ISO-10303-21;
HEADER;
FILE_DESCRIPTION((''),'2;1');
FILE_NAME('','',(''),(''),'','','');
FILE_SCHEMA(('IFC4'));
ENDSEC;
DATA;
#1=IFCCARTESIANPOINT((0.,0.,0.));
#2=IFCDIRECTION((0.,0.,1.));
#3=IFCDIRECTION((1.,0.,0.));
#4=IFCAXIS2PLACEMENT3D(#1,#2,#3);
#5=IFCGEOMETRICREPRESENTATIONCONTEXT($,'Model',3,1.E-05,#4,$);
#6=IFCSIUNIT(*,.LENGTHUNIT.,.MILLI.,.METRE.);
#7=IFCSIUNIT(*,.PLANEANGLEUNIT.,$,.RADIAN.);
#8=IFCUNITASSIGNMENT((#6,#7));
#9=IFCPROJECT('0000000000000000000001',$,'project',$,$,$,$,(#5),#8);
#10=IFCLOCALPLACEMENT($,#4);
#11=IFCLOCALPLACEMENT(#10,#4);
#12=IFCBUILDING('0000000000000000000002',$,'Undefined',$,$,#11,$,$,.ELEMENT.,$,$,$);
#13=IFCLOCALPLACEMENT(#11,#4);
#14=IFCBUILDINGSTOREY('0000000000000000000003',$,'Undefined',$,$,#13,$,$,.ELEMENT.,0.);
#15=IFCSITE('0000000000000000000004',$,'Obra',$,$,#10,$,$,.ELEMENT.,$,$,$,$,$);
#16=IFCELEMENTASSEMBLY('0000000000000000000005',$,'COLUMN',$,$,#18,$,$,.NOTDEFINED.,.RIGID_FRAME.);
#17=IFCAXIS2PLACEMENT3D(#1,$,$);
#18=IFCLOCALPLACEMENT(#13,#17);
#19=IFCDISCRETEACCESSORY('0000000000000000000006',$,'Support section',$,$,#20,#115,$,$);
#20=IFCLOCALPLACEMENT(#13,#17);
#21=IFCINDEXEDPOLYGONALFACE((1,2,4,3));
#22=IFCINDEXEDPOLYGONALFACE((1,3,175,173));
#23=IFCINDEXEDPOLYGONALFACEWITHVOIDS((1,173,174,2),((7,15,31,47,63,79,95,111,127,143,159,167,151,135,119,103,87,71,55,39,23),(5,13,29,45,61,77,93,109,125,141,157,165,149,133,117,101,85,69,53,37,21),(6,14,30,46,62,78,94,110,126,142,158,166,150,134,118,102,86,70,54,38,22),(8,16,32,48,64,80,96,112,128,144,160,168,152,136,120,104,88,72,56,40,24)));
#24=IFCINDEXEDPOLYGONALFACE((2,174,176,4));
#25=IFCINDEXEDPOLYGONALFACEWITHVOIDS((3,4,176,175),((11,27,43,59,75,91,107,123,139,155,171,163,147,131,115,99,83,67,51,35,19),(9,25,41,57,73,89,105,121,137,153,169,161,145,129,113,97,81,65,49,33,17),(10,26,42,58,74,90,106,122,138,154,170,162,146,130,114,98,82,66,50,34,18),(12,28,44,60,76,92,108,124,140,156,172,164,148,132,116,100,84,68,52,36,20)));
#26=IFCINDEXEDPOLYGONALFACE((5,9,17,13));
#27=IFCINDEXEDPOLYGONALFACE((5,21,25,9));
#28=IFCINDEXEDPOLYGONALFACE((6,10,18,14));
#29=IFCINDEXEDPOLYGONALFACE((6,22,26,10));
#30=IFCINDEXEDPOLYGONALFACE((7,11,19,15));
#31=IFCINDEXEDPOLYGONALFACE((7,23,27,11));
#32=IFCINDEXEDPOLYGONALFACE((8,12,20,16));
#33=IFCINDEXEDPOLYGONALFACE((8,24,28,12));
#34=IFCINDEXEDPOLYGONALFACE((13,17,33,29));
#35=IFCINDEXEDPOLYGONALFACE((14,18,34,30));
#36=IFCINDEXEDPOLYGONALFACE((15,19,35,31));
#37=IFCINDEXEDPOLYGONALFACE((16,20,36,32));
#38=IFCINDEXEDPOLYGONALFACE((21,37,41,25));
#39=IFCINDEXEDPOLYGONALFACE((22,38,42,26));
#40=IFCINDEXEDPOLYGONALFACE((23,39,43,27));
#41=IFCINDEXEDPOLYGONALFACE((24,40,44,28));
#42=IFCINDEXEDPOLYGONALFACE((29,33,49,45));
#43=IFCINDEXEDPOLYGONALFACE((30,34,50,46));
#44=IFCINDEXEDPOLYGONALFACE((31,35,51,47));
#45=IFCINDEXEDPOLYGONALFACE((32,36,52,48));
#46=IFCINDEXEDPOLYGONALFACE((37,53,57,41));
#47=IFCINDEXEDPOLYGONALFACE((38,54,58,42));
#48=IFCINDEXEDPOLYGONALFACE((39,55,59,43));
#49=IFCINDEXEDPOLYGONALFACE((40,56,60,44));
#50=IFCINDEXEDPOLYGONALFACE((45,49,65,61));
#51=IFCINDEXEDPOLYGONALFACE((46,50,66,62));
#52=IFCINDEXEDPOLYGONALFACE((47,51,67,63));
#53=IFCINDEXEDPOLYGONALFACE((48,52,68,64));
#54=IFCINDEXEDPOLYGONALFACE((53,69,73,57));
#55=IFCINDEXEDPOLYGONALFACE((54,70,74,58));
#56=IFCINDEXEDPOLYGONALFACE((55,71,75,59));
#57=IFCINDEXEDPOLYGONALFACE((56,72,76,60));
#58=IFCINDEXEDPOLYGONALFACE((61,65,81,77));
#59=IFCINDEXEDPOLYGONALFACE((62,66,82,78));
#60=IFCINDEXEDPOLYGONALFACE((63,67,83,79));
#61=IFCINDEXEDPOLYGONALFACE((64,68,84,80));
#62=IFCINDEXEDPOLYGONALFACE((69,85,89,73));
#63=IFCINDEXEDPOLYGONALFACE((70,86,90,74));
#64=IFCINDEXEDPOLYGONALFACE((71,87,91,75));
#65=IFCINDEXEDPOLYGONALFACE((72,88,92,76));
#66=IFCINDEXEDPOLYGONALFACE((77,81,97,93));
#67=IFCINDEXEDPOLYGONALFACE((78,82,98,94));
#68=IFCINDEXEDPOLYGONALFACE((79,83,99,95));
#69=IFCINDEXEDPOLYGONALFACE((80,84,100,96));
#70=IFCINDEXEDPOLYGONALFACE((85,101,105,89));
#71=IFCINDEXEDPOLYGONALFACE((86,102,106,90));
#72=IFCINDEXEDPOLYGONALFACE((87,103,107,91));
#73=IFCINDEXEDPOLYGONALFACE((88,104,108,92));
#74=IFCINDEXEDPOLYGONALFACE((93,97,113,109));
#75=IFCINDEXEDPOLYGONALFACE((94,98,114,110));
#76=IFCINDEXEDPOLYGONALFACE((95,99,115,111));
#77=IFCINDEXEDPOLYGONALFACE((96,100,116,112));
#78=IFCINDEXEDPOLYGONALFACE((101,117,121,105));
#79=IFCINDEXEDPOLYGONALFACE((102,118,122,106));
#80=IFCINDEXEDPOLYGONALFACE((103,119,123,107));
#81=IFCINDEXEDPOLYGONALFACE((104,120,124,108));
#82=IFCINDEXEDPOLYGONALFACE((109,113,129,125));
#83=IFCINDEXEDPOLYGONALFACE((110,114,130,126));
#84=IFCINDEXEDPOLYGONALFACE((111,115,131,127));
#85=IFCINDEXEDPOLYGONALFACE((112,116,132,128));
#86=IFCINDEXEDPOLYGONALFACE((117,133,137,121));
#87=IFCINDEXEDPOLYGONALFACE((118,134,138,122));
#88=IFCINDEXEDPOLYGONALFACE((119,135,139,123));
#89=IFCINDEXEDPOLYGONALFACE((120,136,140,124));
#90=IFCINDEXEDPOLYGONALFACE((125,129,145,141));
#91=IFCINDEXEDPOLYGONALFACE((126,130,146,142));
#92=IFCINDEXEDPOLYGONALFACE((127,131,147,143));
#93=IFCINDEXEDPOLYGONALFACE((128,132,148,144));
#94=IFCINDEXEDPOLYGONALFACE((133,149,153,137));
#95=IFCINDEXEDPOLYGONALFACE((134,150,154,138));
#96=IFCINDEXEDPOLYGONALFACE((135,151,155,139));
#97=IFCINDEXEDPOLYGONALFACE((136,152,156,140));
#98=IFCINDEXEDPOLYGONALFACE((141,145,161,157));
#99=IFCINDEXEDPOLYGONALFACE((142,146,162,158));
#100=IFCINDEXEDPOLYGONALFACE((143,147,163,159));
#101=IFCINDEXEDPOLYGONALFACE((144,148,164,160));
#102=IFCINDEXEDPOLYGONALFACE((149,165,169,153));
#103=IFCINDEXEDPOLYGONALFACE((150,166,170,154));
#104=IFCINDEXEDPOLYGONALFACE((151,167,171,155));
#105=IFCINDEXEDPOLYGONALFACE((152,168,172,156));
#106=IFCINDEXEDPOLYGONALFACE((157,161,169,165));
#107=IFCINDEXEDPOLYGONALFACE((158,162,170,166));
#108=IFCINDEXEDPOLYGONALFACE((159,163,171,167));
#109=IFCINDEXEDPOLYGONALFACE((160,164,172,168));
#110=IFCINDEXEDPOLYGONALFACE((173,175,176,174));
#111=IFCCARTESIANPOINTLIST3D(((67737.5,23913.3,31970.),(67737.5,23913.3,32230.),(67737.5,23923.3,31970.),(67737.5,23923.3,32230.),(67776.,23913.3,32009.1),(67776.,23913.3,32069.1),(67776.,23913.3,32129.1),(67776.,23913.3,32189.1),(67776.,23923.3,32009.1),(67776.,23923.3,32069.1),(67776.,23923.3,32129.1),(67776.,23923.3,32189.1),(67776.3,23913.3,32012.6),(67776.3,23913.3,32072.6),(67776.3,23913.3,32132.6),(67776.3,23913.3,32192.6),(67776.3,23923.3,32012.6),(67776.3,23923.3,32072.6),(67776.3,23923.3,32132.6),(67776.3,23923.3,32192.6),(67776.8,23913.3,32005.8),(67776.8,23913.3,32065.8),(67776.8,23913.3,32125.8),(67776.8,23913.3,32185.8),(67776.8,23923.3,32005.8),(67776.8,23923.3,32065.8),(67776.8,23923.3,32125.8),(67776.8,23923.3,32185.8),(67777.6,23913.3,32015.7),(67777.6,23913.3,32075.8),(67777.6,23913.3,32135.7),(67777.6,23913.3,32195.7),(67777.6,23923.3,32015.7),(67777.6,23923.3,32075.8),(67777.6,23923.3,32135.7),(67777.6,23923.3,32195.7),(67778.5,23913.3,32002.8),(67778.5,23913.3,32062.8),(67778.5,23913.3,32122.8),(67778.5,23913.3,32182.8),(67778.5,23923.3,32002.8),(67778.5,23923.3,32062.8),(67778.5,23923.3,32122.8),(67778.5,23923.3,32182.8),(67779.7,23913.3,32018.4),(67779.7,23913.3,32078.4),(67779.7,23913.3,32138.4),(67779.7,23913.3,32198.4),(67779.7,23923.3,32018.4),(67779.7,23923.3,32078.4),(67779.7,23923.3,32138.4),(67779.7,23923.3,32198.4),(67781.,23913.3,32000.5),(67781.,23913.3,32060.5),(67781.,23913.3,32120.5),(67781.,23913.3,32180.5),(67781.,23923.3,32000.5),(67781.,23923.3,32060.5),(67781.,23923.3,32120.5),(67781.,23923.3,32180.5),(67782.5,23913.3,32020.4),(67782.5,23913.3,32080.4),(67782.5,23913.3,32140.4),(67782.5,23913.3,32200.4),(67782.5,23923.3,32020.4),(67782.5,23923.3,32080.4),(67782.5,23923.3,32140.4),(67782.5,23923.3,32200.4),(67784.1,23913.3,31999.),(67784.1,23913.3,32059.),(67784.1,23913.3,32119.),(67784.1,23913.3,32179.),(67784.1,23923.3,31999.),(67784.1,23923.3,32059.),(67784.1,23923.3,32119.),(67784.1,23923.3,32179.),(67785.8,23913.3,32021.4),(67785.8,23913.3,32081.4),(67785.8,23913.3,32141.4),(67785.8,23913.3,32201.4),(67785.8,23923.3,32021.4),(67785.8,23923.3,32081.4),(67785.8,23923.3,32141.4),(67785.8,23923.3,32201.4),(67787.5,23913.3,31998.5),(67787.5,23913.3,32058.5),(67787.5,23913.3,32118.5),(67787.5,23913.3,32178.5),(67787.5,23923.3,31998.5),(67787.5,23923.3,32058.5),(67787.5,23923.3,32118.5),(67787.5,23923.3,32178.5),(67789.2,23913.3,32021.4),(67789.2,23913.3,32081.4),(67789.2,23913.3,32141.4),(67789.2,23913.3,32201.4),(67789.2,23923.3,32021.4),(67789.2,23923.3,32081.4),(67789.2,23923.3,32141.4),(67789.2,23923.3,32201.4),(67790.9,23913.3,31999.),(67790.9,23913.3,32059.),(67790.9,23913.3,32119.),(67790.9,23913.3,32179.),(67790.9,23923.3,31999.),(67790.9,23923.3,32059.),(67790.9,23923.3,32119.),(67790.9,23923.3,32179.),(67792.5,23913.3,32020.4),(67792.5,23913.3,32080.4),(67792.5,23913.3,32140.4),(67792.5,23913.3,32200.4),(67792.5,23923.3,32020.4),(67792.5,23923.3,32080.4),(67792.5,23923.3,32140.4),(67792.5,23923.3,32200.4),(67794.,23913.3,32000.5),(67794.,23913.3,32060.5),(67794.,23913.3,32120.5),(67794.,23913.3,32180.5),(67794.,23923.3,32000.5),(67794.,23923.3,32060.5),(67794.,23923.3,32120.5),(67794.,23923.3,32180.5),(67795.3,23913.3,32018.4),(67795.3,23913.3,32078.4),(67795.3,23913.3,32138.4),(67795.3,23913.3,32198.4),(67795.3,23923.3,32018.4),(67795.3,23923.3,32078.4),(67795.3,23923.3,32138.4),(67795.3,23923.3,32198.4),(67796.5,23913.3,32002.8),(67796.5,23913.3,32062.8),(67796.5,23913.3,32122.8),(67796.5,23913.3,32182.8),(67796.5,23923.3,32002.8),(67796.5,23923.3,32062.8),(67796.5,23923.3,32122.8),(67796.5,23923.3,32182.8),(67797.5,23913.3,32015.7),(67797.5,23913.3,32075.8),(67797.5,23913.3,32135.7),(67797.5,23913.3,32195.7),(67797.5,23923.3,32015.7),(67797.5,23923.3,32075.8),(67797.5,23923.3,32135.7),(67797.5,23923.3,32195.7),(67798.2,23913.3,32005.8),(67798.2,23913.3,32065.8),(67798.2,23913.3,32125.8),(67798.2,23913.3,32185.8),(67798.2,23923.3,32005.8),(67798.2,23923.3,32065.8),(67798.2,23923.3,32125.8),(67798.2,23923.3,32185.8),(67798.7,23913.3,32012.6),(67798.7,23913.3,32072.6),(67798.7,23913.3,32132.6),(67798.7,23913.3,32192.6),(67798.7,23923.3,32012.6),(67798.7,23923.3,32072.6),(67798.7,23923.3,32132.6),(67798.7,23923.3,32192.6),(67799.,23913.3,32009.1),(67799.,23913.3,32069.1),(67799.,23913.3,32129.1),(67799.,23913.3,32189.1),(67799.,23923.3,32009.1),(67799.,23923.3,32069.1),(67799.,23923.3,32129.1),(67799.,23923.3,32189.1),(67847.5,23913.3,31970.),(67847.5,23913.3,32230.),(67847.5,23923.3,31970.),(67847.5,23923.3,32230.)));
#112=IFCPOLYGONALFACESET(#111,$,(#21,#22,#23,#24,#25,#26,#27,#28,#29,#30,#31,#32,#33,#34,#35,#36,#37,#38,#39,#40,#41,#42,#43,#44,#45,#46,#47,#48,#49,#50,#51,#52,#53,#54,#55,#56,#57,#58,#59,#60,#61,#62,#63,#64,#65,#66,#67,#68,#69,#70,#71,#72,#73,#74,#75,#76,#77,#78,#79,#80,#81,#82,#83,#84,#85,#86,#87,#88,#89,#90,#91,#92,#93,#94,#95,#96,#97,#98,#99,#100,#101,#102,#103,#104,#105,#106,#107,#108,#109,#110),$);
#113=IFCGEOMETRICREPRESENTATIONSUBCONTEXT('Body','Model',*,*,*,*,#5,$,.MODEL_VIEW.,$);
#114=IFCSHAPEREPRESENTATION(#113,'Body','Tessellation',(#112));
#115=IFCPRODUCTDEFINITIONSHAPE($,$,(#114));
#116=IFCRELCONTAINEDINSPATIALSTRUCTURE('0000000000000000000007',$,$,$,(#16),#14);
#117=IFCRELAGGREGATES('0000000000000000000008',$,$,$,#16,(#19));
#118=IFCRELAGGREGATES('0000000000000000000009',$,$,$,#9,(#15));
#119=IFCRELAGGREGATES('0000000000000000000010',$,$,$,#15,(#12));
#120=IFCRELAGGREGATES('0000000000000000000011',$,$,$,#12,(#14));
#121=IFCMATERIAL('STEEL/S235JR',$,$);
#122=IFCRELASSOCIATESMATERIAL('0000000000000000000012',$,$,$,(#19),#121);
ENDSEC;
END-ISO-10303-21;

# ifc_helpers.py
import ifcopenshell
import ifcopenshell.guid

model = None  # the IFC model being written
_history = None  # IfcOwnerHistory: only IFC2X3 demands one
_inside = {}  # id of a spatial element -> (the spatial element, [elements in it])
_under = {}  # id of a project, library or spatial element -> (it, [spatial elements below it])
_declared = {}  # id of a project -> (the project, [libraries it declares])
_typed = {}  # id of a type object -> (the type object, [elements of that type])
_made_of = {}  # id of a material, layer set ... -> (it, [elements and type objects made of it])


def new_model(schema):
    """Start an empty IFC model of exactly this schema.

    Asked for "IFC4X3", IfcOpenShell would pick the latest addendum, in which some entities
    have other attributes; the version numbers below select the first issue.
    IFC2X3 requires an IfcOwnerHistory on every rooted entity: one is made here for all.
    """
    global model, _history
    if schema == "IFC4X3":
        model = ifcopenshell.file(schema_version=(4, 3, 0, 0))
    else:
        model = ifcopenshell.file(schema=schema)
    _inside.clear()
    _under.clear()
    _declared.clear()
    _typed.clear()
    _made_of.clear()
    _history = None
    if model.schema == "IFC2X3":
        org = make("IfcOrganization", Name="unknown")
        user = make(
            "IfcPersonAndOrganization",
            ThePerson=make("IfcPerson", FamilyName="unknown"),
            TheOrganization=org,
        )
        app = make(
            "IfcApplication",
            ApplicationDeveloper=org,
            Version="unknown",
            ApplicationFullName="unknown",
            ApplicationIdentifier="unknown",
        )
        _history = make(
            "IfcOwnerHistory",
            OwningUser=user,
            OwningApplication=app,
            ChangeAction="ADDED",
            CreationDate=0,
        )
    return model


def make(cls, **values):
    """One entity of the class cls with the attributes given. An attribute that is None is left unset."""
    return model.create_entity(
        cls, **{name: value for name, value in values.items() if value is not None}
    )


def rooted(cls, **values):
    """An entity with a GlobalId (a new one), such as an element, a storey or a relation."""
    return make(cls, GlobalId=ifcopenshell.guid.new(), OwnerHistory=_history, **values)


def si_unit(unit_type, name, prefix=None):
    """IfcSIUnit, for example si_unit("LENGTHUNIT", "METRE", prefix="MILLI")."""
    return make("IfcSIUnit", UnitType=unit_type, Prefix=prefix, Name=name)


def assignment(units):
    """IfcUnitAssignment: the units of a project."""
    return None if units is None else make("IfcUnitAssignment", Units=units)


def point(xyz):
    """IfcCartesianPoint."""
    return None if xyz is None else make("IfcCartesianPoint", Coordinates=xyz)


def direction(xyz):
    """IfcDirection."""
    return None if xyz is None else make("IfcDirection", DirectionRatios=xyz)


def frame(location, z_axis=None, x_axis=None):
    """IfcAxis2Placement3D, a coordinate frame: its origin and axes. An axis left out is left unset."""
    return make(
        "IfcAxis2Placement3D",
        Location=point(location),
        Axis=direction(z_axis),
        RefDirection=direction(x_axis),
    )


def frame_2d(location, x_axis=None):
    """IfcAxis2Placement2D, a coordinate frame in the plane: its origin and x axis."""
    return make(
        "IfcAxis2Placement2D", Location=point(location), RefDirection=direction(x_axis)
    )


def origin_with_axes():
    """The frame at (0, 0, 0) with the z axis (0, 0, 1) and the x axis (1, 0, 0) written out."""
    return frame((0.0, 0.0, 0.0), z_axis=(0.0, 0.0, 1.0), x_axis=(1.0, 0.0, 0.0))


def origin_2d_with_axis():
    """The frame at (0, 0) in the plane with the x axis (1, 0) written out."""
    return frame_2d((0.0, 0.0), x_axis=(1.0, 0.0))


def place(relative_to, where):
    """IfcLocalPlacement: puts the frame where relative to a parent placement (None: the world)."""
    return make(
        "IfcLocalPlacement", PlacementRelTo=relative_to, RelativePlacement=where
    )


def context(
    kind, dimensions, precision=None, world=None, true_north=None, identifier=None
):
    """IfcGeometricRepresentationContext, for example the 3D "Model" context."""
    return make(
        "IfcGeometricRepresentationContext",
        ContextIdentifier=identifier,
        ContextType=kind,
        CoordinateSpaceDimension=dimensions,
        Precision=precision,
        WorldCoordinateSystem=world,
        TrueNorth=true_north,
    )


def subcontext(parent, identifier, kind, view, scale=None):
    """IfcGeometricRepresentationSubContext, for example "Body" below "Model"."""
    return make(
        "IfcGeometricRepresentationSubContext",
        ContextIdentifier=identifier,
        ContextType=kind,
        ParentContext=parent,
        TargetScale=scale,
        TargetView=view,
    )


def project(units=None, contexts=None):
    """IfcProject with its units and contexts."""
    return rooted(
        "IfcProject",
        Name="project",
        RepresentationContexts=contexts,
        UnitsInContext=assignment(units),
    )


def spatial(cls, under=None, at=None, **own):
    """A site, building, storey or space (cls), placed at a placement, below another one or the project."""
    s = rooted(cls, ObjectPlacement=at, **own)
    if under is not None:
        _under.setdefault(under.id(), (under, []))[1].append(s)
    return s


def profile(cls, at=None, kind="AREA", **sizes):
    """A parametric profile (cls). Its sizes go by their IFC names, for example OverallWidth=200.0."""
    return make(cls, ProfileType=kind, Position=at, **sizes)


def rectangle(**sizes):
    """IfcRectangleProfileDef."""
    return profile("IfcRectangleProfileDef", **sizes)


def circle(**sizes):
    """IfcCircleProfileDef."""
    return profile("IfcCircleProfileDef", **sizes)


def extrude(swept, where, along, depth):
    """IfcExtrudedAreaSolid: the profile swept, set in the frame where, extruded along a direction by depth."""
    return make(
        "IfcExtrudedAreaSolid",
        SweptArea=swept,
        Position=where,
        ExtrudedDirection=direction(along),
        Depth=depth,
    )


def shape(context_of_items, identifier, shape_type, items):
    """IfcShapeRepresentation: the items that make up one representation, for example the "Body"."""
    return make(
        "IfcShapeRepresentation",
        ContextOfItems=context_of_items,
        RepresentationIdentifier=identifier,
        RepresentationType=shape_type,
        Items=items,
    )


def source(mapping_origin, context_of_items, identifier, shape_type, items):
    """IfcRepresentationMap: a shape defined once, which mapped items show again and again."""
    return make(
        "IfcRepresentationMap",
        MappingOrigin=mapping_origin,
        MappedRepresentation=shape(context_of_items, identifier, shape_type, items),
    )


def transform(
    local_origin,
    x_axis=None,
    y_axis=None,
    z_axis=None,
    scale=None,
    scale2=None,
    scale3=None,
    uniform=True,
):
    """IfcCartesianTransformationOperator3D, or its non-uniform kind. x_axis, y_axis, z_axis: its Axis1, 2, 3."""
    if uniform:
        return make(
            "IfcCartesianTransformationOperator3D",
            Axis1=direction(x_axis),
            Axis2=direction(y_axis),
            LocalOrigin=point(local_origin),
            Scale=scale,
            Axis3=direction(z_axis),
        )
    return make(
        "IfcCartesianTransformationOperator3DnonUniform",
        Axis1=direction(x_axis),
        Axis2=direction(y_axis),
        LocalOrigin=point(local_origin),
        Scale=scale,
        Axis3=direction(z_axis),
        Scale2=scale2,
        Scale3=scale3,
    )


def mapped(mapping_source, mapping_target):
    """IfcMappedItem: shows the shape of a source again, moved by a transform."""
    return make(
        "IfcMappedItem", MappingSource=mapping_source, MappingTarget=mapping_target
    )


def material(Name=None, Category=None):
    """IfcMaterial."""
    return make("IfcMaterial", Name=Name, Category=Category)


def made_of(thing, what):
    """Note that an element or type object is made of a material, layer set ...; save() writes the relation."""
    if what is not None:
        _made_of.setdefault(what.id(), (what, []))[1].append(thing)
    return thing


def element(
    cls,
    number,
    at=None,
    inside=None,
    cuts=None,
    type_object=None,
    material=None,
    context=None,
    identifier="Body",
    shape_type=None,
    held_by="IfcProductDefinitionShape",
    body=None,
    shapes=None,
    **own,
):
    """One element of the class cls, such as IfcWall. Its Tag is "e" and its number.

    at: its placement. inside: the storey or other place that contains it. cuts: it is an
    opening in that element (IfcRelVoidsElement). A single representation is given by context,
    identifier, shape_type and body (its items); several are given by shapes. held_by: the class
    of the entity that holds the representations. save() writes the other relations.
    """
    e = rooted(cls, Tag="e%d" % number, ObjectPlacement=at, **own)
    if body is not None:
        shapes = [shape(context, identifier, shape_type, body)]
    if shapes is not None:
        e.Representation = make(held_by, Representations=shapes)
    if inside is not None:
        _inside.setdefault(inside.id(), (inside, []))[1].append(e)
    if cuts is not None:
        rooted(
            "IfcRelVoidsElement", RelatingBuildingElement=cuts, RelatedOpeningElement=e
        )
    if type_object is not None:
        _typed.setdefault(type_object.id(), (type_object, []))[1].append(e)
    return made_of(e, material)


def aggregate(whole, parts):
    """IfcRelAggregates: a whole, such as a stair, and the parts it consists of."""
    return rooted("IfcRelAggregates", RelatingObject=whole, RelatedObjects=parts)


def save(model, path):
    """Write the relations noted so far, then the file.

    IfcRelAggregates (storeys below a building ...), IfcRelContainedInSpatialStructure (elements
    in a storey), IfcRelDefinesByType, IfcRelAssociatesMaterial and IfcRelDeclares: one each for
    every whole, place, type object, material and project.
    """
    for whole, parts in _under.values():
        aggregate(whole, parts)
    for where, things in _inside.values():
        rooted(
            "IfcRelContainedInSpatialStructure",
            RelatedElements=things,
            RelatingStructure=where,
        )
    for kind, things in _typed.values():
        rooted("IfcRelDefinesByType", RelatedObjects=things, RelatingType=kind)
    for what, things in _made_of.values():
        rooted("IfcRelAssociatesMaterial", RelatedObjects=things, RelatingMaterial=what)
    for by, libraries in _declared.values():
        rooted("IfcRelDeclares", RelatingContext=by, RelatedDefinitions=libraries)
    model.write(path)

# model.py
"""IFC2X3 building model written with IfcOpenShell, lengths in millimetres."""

from ifc_helpers import new_model, si_unit, frame, origin_with_axes, origin_2d_with_axis, place, context, subcontext, project, spatial, rectangle, circle, extrude, source, transform, mapped, material, element, aggregate, save


model = new_model("IFC2X3")

# Units and contexts
model_context = context("Model", 3, precision=1e-05, world=origin_with_axes())
body_context = subcontext(model_context, "Body", "Model", "MODEL_VIEW")
ifc_project = project(units=[si_unit("LENGTHUNIT", "METRE", prefix="MILLI"), si_unit("PLANEANGLEUNIT", "RADIAN")], contexts=[model_context])

# Site, building, storey
site_placement = place(None, origin_with_axes())
site = spatial("IfcSite", under=ifc_project, at=site_placement, Name="Obra", CompositionType="ELEMENT")
building_placement = place(site_placement, origin_with_axes())
building = spatial("IfcBuilding", under=site, at=building_placement, Name="Undefined", CompositionType="ELEMENT")
storey_placement = place(building_placement, origin_with_axes())
storey = spatial("IfcBuildingStorey", under=building, at=storey_placement, Name="Undefined", CompositionType="ELEMENT", Elevation=0.0)

# Element assembly
assembly_1_placement = place(storey_placement, origin_with_axes())
assembly_1 = element("IfcElementAssembly", 1, at=assembly_1_placement, inside=storey, Name="COLUMN", AssemblyPlace="NOTDEFINED", PredefinedType="RIGID_FRAME")
ifc_material_1 = material(Name="STEEL/S235JR")

# Discrete accessory, opening
discrete_accessory_1_placement = place(assembly_1_placement, frame((67792.5, 23918.3, 31970.0), z_axis=(0.0, 0.0, 1.0), x_axis=(1.0, 0.0, 0.0)))
discrete_accessory_1 = element("IfcDiscreteAccessory", 2, at=discrete_accessory_1_placement, material=ifc_material_1, Name="Support section", context=body_context, shape_type="SweptSolid", body=[
    extrude(rectangle(XDim=10.0, YDim=110.0, at=origin_2d_with_axis()), frame((0.0, 0.0, 260.0), z_axis=(0.0, 0.0, -1.0), x_axis=(0.0, 1.0, 0.0)), (0.0, 0.0, 1.0), 260.0),
])
shared_shape_1 = source(origin_with_axes(), body_context, "Body", "SweptSolid", [
    extrude(circle(Radius=11.5, at=origin_2d_with_axis()), frame((0.0, -14.4, 0.0), z_axis=(0.0, 1.0, 0.0), x_axis=(1.0, 0.0, 0.0)), (0.0, 0.0, 1.0), 10.2),
])
opening_1_placement = place(assembly_1_placement, frame((67837.5, 23909.0, 32300.0), z_axis=(-1.0, 0.0, 0.0), x_axis=(0.0, 0.0, -1.0)))
element("IfcOpeningElement", 3, at=opening_1_placement, cuts=discrete_accessory_1, ObjectType="Opening", context=body_context, shape_type="MappedRepresentation", body=[
    mapped(shared_shape_1, transform((110.0, 0.0, 50.0))),
    mapped(shared_shape_1, transform((170.0, 0.0, 50.0))),
    mapped(shared_shape_1, transform((230.0, 0.0, 50.0))),
    mapped(shared_shape_1, transform((290.0, 0.0, 50.0))),
])
aggregate(assembly_1, [discrete_accessory_1])

save(model, "model.ifc")
